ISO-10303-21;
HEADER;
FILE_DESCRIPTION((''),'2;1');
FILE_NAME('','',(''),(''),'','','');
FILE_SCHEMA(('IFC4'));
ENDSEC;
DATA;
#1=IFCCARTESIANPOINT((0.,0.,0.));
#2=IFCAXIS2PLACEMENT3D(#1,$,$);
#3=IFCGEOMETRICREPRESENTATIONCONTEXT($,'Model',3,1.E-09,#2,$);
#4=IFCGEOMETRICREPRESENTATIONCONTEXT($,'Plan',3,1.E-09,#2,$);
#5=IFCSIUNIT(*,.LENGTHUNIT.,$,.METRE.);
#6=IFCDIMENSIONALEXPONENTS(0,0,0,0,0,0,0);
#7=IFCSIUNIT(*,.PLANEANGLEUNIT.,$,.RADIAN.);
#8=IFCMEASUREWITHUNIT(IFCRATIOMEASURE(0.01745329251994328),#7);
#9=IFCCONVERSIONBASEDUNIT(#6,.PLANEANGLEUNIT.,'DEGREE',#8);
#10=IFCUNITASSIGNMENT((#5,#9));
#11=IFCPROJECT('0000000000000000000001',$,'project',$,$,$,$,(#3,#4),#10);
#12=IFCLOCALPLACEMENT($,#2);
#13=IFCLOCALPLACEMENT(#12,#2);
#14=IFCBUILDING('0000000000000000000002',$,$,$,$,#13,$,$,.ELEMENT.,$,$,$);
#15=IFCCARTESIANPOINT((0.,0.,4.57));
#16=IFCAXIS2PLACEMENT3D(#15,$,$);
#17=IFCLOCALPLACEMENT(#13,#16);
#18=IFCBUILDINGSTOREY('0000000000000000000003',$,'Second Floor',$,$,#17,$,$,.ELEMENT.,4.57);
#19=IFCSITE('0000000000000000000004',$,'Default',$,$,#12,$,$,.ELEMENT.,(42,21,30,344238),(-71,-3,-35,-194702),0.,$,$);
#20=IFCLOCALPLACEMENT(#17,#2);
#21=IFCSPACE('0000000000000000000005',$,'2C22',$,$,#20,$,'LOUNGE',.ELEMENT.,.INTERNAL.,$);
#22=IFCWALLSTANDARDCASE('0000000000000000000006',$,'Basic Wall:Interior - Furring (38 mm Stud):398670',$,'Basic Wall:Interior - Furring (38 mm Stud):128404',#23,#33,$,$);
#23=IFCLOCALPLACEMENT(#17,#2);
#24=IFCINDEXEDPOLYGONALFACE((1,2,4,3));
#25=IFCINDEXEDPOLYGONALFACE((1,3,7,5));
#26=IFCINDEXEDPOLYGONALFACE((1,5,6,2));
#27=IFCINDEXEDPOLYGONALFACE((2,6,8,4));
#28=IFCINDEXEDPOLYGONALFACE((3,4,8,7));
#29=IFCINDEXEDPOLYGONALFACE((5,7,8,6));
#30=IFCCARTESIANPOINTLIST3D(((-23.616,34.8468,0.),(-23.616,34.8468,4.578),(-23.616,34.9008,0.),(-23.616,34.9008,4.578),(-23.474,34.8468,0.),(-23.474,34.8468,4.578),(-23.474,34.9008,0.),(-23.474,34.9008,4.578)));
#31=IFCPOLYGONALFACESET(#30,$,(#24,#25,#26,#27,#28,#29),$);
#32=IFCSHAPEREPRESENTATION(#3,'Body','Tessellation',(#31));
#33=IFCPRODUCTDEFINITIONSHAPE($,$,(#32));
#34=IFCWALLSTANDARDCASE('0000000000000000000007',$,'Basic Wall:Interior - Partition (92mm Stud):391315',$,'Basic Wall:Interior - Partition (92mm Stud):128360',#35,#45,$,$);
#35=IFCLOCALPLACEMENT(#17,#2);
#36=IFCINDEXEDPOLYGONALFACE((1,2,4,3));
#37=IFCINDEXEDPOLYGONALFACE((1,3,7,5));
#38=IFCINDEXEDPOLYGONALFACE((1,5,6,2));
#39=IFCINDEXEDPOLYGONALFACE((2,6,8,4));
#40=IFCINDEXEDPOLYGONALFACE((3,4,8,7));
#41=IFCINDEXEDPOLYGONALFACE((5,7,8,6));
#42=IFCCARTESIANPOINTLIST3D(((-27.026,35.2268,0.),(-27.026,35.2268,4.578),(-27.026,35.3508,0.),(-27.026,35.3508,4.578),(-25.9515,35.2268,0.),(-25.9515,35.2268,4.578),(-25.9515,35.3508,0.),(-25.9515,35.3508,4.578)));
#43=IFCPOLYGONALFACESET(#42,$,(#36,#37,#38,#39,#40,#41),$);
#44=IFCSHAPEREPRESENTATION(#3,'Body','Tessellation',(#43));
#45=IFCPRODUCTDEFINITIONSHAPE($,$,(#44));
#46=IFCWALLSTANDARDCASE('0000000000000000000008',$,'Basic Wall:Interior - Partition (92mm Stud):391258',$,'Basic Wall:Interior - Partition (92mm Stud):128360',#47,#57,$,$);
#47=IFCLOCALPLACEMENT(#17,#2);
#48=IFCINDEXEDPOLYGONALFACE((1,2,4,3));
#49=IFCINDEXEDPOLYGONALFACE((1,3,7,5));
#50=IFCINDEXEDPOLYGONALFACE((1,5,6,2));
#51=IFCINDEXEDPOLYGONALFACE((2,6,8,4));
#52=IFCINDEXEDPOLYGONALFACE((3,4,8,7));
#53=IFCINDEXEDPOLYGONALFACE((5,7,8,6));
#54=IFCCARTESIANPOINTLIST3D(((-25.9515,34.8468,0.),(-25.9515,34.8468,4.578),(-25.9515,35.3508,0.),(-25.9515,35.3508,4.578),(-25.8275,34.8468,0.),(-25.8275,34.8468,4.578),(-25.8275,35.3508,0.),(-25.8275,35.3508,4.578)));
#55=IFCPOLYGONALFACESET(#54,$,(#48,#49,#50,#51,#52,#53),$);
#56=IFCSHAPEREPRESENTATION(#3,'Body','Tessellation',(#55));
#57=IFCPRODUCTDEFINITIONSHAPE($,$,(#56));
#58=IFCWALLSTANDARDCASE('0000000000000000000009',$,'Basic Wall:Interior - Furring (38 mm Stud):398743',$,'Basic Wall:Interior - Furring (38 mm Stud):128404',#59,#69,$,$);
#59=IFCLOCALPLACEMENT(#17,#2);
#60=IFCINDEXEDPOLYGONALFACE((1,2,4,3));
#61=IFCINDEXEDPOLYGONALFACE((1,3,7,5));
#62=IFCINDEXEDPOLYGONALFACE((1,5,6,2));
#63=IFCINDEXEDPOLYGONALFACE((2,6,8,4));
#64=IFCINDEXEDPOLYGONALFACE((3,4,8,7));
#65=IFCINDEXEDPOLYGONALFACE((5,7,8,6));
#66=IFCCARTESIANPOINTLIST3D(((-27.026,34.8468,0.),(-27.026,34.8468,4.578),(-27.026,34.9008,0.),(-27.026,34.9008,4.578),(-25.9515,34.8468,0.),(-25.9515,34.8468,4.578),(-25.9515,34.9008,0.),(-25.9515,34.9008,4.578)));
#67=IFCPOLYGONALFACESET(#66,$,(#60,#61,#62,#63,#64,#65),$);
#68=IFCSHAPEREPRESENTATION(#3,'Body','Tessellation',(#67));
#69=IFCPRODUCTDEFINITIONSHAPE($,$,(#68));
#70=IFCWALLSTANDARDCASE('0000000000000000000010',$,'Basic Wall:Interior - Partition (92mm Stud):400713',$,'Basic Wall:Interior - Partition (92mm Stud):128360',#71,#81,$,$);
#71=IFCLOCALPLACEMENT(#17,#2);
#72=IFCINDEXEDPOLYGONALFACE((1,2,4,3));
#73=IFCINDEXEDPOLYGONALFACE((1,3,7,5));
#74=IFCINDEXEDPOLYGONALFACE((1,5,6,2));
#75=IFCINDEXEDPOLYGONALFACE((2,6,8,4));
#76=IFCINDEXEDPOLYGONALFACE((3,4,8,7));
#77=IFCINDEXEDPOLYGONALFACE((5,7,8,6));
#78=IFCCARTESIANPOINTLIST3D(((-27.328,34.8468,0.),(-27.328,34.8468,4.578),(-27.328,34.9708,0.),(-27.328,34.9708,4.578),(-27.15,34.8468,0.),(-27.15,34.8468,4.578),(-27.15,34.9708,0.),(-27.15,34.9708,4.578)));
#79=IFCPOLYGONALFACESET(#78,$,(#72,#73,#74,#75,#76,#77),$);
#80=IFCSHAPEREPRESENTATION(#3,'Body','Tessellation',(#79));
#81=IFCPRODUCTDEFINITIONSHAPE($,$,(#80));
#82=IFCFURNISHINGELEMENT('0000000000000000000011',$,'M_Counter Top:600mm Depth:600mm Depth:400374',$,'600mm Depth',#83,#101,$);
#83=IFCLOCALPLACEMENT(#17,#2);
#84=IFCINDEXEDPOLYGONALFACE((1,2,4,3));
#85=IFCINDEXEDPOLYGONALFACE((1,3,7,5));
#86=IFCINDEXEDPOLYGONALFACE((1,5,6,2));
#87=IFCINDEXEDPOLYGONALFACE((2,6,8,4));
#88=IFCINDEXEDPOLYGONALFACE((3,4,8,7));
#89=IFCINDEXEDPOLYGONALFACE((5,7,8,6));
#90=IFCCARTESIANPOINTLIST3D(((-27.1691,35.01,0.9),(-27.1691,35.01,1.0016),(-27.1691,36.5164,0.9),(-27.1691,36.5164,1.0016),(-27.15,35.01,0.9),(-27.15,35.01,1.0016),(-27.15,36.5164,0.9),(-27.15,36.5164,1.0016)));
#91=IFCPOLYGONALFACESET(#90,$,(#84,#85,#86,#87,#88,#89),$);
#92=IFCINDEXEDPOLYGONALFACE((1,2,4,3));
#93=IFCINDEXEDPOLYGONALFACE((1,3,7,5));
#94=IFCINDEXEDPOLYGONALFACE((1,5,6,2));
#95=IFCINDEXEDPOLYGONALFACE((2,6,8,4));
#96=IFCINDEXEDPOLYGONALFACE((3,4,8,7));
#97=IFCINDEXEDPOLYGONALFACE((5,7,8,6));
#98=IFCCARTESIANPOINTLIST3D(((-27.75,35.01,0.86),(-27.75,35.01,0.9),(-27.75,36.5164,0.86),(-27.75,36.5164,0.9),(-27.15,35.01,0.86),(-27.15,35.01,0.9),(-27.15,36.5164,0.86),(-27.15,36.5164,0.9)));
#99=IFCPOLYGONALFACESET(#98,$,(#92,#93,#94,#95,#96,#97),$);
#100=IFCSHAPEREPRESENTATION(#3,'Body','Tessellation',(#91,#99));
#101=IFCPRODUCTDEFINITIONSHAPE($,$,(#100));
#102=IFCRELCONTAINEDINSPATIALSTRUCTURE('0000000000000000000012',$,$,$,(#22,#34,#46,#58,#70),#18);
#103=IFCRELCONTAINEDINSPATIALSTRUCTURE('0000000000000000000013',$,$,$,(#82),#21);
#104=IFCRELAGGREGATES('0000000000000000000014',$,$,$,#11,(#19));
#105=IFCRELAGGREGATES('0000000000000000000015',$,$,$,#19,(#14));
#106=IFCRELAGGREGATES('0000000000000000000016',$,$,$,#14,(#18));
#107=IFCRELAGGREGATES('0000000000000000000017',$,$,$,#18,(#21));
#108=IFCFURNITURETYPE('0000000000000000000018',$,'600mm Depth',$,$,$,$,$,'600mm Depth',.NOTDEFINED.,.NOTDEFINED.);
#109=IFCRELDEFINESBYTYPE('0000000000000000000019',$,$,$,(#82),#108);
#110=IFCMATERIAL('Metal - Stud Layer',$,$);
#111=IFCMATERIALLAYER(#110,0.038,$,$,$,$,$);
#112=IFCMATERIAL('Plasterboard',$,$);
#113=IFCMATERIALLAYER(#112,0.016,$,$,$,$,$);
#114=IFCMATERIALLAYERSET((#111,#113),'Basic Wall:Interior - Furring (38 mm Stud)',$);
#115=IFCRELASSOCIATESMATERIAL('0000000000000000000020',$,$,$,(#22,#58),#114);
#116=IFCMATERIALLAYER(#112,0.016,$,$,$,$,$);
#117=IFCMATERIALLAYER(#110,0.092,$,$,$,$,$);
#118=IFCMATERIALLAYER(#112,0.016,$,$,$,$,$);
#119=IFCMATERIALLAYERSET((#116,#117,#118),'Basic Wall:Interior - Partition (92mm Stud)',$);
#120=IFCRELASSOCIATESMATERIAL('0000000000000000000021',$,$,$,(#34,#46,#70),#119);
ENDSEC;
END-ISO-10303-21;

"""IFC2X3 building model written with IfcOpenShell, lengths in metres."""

from ifc_helpers import new_model, entity, si_unit, converted_unit, frame, frame_2d, origin, origin_2d_with_axis, place, context, project, spatial, rectangle, extrude, source, transform, mapped, material, layer, layer_set, layer_usage, type_object, type_shapes, element, save


model = new_model("IFC2X3")

# Units and contexts
model_context = context("Model", 3, precision=1e-09, world=origin())
plan_context = context("Plan", 3, precision=1e-09, world=origin())
ifc_project = project(units=[si_unit("LENGTHUNIT", "METRE"), converted_unit("PLANEANGLEUNIT", "DEGREE", entity("IfcRatioMeasure", 0.01745329251994328), si_unit("PLANEANGLEUNIT", "RADIAN"), dimensions=[0, 0, 0, 0, 0, 0, 0])], contexts=[model_context, plan_context])

# Site, building, storey
site_placement = place(None, origin())
site = spatial("IfcSite", under=ifc_project, at=site_placement, Name="Default", CompositionType="ELEMENT", RefLatitude=(42, 21, 30, 344238), RefLongitude=(-71, -3, -35, -194702), RefElevation=0.0)
building_placement = place(site_placement, origin())
building = spatial("IfcBuilding", under=site, at=building_placement, CompositionType="ELEMENT")
storey_placement = place(building_placement, frame((0.0, 0.0, 4.57)))
storey = spatial("IfcBuildingStorey", under=building, at=storey_placement, Name="Second Floor", CompositionType="ELEMENT", Elevation=4.57)

# Shared definitions
ifc_material_1 = material(Name="Plasterboard")
ifc_layer_1 = layer(ifc_material_1, 0.016)
ifc_material_2 = material(Name="Metal - Stud Layer")
ifc_layer_2 = layer(ifc_material_2, 0.092)
ifc_layer_3 = layer(ifc_material_1, 0.016)
ifc_layer_set_1 = layer_set([ifc_layer_1, ifc_layer_2, ifc_layer_3], Name="Basic Wall:Interior - Partition (92mm Stud)")
ifc_layer_usage_1 = layer_usage(ifc_layer_set_1, "AXIS2", "NEGATIVE", 0.062)

# Shared definitions
ifc_layer_4 = layer(ifc_material_2, 0.038)
ifc_layer_5 = layer(ifc_material_1, 0.016)
ifc_layer_set_2 = layer_set([ifc_layer_4, ifc_layer_5], Name="Basic Wall:Interior - Furring (38 mm Stud)")

# Walls
ifc_layer_usage_2 = layer_usage(ifc_layer_set_2, "AXIS2", "NEGATIVE", 0.027)
wall_1_placement = place(storey_placement, frame((-23.616, 34.8738, 0.0)))
element("IfcWallStandardCase", 1, at=wall_1_placement, inside=storey, material=ifc_layer_usage_2, Name="Basic Wall:Interior - Furring (38 mm Stud):398670", ObjectType="Basic Wall:Interior - Furring (38 mm Stud):128404", context=model_context, shape_type="SweptSolid", body=[
    extrude(rectangle(XDim=0.142, YDim=0.054, at=frame_2d((0.071, 0.0), x_axis=(-1.0, 0.0))), origin(), (0.0, 0.0, 1.0), 4.578),
])
wall_2_placement = place(storey_placement, frame((-25.9515, 35.2888, 0.0), z_axis=(0.0, 0.0, 1.0), x_axis=(-1.0, 0.0, 0.0)))
element("IfcWallStandardCase", 2, at=wall_2_placement, inside=storey, material=ifc_layer_usage_1, Name="Basic Wall:Interior - Partition (92mm Stud):391315", ObjectType="Basic Wall:Interior - Partition (92mm Stud):128360", context=model_context, shape_type="SweptSolid", body=[
    extrude(rectangle(XDim=1.0745, YDim=0.124, at=frame_2d((0.5372, 0.0), x_axis=(-1.0, 0.0))), origin(), (0.0, 0.0, 1.0), 4.578),
])
wall_3_placement = place(storey_placement, frame((-25.8895, 34.8468, 0.0), z_axis=(0.0, 0.0, 1.0), x_axis=(0.0, 1.0, 0.0)))
element("IfcWallStandardCase", 3, at=wall_3_placement, inside=storey, material=ifc_layer_usage_1, Name="Basic Wall:Interior - Partition (92mm Stud):391258", ObjectType="Basic Wall:Interior - Partition (92mm Stud):128360", context=model_context, shape_type="SweptSolid", body=[
    extrude(rectangle(XDim=0.504, YDim=0.124, at=frame_2d((0.252, 0.0), x_axis=(-1.0, 0.0))), origin(), (0.0, 0.0, 1.0), 4.578),
])
wall_4_placement = place(storey_placement, frame((-27.026, 34.8738, 0.0)))
element("IfcWallStandardCase", 4, at=wall_4_placement, inside=storey, material=ifc_layer_usage_2, Name="Basic Wall:Interior - Furring (38 mm Stud):398743", ObjectType="Basic Wall:Interior - Furring (38 mm Stud):128404", context=model_context, shape_type="SweptSolid", body=[
    extrude(rectangle(XDim=1.0745, YDim=0.054, at=frame_2d((0.5372, 0.0), x_axis=(-1.0, 0.0))), origin(), (0.0, 0.0, 1.0), 4.578),
])
wall_5_placement = place(storey_placement, frame((-27.15, 34.9088, 0.0), z_axis=(0.0, 0.0, 1.0), x_axis=(-1.0, 0.0, 0.0)))
element("IfcWallStandardCase", 5, at=wall_5_placement, inside=storey, material=ifc_layer_usage_1, Name="Basic Wall:Interior - Partition (92mm Stud):400713", ObjectType="Basic Wall:Interior - Partition (92mm Stud):128360", context=model_context, shape_type="SweptSolid", body=[
    extrude(rectangle(XDim=0.178, YDim=0.124, at=frame_2d((0.089, 0.0), x_axis=(-1.0, 0.0))), origin(), (0.0, 0.0, 1.0), 4.578),
])

# Shared definitions
space_placement = place(storey_placement, origin())
space = spatial("IfcSpace", under=storey, at=space_placement, Name="2C22", LongName="LOUNGE", CompositionType="ELEMENT", InteriorOrExteriorSpace="INTERNAL")

# Furnishing element
furniture_type = type_object("IfcFurnitureType", Name="600mm Depth", ElementType="600mm Depth", AssemblyPlace="NOTDEFINED")
shared_shape_1 = source(origin(), model_context, "Body", "SweptSolid", [
    extrude(rectangle(XDim=0.0191, YDim=1.5064, at=origin_2d_with_axis()), frame((-0.4472, -0.0095, 0.9), z_axis=(0.0, 0.0, 1.0), x_axis=(0.0, -1.0, 0.0)), (0.0, 0.0, 1.0), 0.1016),
    extrude(rectangle(XDim=1.5064, YDim=0.6, at=origin_2d_with_axis()), frame((-0.4472, -0.3, 0.86), z_axis=(0.0, 0.0, 1.0), x_axis=(-1.0, 0.0, 0.0)), (0.0, 0.0, 1.0), 0.04),
])
type_shapes(furniture_type, [shared_shape_1])
furnishing_placement = place(space_placement, frame((-27.15, 35.316, 0.0), z_axis=(0.0, 0.0, 1.0), x_axis=(0.0, -1.0, 0.0)))
element("IfcFurnishingElement", 6, at=furnishing_placement, inside=space, type_object=furniture_type, Name="M_Counter Top:600mm Depth:600mm Depth:400374", ObjectType="600mm Depth", context=model_context, shape_type="MappedRepresentation", body=[
    mapped(shared_shape_1, transform((0.0, 0.0, 0.0), scale=1.0)),
])

save(model, "model.ifc")
